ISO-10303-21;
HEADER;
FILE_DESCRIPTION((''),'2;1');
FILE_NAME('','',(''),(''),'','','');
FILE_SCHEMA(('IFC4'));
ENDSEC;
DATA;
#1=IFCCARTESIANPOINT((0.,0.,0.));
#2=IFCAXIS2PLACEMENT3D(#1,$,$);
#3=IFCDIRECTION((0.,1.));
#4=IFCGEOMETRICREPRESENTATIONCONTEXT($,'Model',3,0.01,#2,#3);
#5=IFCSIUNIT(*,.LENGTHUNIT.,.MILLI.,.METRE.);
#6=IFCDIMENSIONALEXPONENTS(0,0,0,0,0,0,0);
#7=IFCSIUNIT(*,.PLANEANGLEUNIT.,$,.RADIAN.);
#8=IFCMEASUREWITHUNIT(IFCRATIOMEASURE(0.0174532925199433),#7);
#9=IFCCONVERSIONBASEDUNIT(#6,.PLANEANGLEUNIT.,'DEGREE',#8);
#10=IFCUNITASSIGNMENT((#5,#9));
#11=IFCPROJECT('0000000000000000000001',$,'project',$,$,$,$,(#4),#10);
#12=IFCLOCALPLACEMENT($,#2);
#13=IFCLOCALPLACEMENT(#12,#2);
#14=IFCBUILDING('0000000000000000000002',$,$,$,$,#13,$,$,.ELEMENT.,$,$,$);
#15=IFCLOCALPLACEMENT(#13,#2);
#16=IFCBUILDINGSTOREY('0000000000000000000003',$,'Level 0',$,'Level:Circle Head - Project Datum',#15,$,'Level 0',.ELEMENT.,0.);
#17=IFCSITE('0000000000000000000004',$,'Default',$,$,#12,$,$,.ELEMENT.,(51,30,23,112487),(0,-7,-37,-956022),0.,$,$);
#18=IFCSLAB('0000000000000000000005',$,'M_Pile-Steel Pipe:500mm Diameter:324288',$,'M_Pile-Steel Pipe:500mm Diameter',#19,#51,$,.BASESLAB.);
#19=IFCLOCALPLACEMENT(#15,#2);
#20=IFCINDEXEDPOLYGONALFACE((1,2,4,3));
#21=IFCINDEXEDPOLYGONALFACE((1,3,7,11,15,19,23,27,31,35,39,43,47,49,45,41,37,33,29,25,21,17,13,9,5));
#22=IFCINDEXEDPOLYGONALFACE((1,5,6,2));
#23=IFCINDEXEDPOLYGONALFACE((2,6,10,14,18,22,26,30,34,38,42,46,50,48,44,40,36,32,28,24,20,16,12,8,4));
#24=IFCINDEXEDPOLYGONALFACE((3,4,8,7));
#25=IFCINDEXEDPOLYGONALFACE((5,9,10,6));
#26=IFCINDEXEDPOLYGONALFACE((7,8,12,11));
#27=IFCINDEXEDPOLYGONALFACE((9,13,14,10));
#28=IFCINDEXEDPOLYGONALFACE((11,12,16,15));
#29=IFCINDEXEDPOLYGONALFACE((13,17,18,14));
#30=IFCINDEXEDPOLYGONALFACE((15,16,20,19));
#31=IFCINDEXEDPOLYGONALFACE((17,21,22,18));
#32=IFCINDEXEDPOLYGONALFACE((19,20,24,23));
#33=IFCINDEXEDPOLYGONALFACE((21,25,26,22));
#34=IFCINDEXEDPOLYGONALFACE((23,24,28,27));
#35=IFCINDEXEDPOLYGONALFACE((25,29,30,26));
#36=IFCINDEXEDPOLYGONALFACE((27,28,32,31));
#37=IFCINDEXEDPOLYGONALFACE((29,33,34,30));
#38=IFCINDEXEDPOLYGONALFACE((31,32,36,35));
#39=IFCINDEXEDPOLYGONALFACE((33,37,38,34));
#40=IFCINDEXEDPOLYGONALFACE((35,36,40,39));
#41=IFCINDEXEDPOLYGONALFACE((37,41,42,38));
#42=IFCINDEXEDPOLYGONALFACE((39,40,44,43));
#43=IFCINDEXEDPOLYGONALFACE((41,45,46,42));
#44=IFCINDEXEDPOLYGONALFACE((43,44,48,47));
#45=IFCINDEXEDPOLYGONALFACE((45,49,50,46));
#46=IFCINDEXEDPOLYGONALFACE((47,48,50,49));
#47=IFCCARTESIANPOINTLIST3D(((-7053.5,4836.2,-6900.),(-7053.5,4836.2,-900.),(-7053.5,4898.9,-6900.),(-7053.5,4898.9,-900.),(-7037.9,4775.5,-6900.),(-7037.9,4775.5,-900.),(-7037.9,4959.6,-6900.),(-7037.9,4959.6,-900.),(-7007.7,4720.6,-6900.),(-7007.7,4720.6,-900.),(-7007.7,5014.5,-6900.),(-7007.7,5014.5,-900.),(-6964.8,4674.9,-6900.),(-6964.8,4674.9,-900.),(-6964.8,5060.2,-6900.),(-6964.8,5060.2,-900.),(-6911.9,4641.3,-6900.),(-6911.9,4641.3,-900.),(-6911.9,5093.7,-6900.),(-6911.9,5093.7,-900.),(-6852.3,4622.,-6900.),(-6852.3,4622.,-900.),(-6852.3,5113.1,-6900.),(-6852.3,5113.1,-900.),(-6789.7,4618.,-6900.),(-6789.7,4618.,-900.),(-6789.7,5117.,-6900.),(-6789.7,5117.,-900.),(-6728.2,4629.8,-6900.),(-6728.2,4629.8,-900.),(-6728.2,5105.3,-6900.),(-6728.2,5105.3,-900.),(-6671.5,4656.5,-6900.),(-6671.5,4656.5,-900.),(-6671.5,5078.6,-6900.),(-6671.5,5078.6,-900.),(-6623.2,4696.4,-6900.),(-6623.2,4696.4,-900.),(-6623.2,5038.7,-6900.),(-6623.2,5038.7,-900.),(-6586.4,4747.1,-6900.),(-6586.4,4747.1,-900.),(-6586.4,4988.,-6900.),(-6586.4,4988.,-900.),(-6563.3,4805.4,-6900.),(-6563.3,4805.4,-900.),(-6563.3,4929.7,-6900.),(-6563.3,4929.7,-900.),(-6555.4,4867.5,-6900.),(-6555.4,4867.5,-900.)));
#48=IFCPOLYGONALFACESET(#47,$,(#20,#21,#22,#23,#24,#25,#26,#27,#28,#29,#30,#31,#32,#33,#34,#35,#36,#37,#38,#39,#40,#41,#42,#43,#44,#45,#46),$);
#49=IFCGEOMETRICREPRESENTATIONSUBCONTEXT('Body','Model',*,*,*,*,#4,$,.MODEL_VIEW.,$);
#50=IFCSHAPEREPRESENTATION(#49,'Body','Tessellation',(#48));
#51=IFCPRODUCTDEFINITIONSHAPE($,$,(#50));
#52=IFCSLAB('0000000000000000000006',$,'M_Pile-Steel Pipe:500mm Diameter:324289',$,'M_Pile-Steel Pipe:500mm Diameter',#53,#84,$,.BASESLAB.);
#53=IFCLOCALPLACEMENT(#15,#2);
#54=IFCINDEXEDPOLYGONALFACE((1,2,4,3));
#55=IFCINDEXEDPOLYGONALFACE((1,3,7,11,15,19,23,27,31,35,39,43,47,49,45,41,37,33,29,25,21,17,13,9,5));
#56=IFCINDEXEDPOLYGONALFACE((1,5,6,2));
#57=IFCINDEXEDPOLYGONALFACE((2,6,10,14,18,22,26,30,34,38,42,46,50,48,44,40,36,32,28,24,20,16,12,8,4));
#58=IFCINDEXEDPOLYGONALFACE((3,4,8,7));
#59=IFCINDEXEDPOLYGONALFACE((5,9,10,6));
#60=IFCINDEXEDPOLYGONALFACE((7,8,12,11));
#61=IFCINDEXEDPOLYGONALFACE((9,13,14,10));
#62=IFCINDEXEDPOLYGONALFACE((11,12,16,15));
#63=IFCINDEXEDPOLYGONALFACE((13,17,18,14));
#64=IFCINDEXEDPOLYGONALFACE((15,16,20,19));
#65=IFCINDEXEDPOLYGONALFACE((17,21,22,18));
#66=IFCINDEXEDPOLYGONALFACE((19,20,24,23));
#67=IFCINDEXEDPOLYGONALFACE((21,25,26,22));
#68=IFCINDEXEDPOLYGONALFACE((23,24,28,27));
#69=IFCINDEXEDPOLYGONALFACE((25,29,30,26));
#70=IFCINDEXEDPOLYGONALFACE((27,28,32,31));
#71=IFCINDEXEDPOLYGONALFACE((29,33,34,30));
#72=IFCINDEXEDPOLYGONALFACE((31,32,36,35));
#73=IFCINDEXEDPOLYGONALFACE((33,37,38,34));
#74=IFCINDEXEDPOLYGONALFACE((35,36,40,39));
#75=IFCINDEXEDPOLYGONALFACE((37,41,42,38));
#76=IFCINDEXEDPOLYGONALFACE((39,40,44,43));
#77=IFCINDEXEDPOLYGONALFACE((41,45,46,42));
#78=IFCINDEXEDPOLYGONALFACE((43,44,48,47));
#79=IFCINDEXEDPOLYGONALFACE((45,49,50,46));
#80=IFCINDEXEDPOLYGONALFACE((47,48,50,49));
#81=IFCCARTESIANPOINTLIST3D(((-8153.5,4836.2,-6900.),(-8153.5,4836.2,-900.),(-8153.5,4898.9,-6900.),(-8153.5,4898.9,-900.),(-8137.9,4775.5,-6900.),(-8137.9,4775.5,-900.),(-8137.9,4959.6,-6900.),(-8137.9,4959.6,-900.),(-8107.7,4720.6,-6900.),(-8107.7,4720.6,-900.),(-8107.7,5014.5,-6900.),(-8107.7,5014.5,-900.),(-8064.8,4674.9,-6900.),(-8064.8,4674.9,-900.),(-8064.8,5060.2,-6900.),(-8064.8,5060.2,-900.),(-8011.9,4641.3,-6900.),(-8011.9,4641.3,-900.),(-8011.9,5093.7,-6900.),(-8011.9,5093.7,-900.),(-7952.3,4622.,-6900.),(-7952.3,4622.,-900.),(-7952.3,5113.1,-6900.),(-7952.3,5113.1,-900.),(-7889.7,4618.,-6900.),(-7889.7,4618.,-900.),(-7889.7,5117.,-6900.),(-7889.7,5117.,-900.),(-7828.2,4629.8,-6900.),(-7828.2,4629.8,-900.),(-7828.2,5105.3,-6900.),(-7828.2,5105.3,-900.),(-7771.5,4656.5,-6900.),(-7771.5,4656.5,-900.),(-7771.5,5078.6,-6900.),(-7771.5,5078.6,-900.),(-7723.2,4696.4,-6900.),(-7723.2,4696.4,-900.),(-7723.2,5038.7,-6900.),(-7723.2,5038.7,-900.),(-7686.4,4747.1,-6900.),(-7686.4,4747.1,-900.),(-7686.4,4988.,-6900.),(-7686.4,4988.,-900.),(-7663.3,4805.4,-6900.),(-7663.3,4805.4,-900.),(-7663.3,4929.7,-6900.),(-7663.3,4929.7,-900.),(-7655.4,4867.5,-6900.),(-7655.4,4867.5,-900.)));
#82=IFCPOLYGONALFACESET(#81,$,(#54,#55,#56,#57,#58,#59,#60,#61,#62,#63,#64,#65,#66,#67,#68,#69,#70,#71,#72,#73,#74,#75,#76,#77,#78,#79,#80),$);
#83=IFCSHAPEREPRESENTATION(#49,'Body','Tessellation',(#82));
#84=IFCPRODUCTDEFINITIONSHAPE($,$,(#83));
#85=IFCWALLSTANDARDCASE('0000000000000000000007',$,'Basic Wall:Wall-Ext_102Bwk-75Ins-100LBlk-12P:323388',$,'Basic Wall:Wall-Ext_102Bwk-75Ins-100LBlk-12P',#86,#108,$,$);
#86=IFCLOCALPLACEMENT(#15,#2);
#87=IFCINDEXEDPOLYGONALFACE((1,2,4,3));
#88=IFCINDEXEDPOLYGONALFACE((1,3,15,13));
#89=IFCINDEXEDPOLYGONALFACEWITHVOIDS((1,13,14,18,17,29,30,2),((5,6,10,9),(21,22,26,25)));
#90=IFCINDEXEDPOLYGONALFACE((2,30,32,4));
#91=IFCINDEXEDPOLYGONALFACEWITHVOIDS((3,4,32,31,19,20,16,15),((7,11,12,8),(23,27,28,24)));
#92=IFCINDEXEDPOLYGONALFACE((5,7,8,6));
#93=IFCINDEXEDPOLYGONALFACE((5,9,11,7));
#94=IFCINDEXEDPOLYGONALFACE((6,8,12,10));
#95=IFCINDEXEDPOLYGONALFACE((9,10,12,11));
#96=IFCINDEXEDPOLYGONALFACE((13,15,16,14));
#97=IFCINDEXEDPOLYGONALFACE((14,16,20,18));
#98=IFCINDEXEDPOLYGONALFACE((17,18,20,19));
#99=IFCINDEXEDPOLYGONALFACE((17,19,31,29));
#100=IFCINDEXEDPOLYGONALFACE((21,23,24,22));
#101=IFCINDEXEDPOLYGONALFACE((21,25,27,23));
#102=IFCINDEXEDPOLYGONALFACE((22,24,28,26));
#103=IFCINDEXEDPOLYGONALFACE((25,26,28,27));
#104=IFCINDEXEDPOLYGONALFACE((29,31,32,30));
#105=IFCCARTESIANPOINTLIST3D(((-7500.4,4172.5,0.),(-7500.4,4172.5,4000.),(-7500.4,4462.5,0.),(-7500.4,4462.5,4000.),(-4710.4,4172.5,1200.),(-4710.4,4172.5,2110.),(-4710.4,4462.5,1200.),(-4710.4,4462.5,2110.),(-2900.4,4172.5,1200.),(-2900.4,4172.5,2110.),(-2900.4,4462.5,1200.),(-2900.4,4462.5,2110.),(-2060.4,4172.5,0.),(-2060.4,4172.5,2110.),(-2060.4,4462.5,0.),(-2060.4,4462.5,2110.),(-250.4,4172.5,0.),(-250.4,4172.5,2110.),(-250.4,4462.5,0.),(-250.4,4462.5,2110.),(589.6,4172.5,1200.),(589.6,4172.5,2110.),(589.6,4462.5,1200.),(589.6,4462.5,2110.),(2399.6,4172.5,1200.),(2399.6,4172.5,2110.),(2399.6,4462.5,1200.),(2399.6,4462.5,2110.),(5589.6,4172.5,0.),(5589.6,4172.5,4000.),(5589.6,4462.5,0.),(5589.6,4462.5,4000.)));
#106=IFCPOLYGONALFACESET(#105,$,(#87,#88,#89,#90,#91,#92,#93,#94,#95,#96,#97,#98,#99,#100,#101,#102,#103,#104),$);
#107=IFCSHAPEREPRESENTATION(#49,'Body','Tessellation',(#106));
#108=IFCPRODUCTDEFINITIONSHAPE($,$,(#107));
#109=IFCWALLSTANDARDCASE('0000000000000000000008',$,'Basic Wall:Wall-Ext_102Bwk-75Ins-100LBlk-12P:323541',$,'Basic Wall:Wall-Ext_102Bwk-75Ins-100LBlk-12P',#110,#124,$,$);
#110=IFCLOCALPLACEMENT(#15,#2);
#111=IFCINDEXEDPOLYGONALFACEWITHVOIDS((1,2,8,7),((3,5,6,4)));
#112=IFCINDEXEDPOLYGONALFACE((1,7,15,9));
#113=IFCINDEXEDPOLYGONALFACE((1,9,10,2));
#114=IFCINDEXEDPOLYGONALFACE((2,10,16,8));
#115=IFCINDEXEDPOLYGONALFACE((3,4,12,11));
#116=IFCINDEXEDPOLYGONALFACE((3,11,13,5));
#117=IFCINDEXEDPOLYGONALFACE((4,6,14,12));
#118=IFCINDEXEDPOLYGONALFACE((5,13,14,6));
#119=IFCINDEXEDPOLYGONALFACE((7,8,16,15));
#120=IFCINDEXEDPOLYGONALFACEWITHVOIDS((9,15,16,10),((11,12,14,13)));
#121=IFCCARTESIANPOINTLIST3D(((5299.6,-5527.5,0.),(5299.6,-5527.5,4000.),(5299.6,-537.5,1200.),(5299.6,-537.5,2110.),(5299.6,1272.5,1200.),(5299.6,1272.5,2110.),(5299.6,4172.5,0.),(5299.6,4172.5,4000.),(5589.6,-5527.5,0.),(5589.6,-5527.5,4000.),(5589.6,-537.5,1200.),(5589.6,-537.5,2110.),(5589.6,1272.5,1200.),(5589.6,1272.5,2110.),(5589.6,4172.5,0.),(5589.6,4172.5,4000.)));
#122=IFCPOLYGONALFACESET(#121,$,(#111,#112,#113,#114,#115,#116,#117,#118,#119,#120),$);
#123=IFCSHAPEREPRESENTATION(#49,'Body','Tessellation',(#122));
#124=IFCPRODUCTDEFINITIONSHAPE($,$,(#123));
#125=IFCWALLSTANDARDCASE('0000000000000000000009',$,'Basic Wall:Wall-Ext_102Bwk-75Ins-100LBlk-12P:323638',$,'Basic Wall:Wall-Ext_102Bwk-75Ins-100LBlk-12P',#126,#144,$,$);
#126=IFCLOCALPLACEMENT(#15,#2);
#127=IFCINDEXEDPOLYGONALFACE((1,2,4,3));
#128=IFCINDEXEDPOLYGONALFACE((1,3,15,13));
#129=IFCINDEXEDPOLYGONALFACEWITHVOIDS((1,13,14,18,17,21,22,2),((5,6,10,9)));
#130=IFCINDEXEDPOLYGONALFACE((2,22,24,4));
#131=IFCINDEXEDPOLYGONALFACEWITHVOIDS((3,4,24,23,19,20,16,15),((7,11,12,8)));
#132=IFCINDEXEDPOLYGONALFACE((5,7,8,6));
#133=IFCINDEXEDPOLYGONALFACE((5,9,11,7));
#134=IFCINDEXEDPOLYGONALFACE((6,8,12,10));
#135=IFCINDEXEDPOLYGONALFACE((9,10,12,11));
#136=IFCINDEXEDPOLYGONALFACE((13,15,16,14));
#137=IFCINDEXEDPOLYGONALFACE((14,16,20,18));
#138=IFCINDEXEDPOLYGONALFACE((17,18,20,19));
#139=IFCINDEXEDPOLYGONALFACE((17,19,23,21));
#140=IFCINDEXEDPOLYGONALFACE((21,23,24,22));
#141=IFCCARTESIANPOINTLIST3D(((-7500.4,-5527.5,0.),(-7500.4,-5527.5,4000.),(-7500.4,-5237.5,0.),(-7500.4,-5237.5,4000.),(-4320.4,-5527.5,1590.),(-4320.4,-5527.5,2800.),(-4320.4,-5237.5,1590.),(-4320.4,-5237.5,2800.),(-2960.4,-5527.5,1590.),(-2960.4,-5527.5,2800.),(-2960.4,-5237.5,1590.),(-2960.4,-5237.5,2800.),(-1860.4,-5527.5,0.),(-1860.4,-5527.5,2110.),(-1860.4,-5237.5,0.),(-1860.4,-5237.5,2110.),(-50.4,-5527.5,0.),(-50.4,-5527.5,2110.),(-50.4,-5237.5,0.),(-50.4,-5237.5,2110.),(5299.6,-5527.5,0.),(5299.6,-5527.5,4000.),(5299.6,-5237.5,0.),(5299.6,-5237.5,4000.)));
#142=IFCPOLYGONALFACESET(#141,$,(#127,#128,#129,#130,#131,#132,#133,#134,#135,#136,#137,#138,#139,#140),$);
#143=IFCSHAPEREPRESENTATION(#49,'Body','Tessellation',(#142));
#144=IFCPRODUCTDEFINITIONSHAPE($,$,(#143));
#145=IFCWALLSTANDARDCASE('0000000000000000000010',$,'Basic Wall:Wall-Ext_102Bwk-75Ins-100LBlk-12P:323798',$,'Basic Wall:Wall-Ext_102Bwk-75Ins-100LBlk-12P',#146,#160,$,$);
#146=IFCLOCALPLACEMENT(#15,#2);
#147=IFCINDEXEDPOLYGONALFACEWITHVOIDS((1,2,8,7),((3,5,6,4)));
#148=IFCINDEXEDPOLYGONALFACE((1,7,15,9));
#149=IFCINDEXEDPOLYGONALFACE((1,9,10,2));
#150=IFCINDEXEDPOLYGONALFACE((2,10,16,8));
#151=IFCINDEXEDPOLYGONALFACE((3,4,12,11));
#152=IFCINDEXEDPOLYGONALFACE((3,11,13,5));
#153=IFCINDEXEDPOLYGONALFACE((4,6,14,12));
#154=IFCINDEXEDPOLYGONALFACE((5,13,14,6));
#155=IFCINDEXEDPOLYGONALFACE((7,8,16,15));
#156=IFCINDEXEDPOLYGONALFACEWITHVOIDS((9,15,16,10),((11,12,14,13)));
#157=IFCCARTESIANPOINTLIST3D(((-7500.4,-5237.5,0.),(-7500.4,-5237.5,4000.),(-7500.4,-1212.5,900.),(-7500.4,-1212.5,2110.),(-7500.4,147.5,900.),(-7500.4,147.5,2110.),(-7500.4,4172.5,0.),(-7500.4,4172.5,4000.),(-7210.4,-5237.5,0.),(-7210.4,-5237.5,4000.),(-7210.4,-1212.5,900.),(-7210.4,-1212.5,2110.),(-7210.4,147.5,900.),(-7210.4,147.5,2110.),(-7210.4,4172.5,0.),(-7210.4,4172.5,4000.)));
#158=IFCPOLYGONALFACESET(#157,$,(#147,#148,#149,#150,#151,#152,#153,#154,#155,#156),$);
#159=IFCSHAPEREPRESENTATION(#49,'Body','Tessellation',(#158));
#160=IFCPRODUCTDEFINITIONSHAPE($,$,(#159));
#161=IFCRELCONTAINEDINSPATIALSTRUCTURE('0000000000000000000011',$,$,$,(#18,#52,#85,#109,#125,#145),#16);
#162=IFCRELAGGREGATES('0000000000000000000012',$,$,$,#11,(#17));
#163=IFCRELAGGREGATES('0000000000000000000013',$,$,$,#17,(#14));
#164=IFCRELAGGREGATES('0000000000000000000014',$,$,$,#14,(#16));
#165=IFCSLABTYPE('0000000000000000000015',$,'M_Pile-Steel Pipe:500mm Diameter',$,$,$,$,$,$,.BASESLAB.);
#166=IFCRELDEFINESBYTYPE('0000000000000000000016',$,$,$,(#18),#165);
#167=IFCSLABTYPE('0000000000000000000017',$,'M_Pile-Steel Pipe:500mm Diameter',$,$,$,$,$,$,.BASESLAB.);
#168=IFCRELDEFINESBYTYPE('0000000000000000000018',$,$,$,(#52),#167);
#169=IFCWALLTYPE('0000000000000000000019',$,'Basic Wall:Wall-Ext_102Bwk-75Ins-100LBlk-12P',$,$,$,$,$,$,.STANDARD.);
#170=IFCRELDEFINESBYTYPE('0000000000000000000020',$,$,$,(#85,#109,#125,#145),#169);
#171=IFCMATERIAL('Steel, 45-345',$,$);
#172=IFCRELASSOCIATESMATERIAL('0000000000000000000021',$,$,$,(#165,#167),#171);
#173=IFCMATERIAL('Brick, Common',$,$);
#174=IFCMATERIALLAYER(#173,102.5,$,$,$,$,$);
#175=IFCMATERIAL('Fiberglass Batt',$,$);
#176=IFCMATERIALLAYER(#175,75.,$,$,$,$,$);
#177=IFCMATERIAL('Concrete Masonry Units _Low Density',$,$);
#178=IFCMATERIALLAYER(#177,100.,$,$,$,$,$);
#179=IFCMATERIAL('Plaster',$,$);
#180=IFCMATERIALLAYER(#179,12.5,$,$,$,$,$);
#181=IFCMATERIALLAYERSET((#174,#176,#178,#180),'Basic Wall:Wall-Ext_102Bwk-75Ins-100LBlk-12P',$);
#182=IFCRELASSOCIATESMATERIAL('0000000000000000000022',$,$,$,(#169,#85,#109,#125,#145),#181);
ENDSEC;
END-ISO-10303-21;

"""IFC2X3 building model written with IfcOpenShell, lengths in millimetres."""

from ifc_helpers import new_model, entity, si_unit, converted_unit, direction, frame, frame_2d, origin, place, context, subcontext, project, spatial, rectangle, circle, extrude, material, layer, layer_set, layer_usage, type_object, element, save


model = new_model("IFC2X3")

# Units and contexts
model_context = context("Model", 3, precision=0.01, world=origin(), true_north=direction((0.0, 1.0)))
body_context = subcontext(model_context, "Body", "Model", "MODEL_VIEW")
ifc_project = project(units=[si_unit("LENGTHUNIT", "METRE", prefix="MILLI"), converted_unit("PLANEANGLEUNIT", "DEGREE", entity("IfcRatioMeasure", 0.0174532925199433), si_unit("PLANEANGLEUNIT", "RADIAN"), dimensions=[0, 0, 0, 0, 0, 0, 0])], contexts=[model_context])

# Site, building, storey
site_placement = place(None, origin())
site = spatial("IfcSite", under=ifc_project, at=site_placement, Name="Default", CompositionType="ELEMENT", RefLatitude=(51, 30, 23, 112487), RefLongitude=(0, -7, -37, -956022), RefElevation=0.0)
building_placement = place(site_placement, origin())
building = spatial("IfcBuilding", under=site, at=building_placement, CompositionType="ELEMENT")
storey_placement = place(building_placement, origin())
storey = spatial("IfcBuildingStorey", under=building, at=storey_placement, Name="Level 0", ObjectType="Level:Circle Head - Project Datum", LongName="Level 0", CompositionType="ELEMENT", Elevation=0.0)

# Slabs
ifc_material_1 = material(Name="Steel, 45-345")
slab_type_1 = type_object("IfcSlabType", Name="M_Pile-Steel Pipe:500mm Diameter", PredefinedType="BASESLAB", material=ifc_material_1)
slab_1_placement = place(storey_placement, origin())
element("IfcSlab", 1, at=slab_1_placement, inside=storey, type_object=slab_type_1, Name="M_Pile-Steel Pipe:500mm Diameter:324288", ObjectType="M_Pile-Steel Pipe:500mm Diameter", PredefinedType="BASESLAB", context=body_context, shape_type="SweptSolid", body=[
    extrude(circle(Radius=250.0, at=frame_2d((0.0, 0.0), x_axis=(1.0, 0.0))), frame((-6805.4, 4867.5, -6900.0)), (0.0, 0.0, 1.0), 6000.0),
])
slab_type_2 = type_object("IfcSlabType", Name="M_Pile-Steel Pipe:500mm Diameter", PredefinedType="BASESLAB", material=ifc_material_1)
slab_2_placement = place(storey_placement, origin())
element("IfcSlab", 2, at=slab_2_placement, inside=storey, type_object=slab_type_2, Name="M_Pile-Steel Pipe:500mm Diameter:324289", ObjectType="M_Pile-Steel Pipe:500mm Diameter", PredefinedType="BASESLAB", context=body_context, shape_type="SweptSolid", body=[
    extrude(circle(Radius=250.0, at=frame_2d((0.0, 0.0), x_axis=(1.0, 0.0))), frame((-7905.4, 4867.5, -6900.0)), (0.0, 0.0, 1.0), 6000.0),
])

# Wall, openings
ifc_material_2 = material(Name="Brick, Common")
ifc_layer_1 = layer(ifc_material_2, 102.5)
ifc_material_3 = material(Name="Fiberglass Batt")
ifc_layer_2 = layer(ifc_material_3, 75.0)
ifc_material_4 = material(Name="Concrete Masonry Units _Low Density")
ifc_layer_3 = layer(ifc_material_4, 100.0)
ifc_material_5 = material(Name="Plaster")
ifc_layer_4 = layer(ifc_material_5, 12.5)
ifc_layer_set_1 = layer_set([ifc_layer_1, ifc_layer_2, ifc_layer_3, ifc_layer_4], Name="Basic Wall:Wall-Ext_102Bwk-75Ins-100LBlk-12P")
ifc_layer_usage_1 = layer_usage(ifc_layer_set_1, "AXIS2", "NEGATIVE", 145.0)
wall_type = type_object("IfcWallType", Name="Basic Wall:Wall-Ext_102Bwk-75Ins-100LBlk-12P", PredefinedType="STANDARD", material=ifc_layer_set_1)
wall_1_placement = place(storey_placement, frame((-7500.4, 4317.5, 0.0)))
wall_1 = element("IfcWallStandardCase", 3, at=wall_1_placement, inside=storey, type_object=wall_type, material=ifc_layer_usage_1, Name="Basic Wall:Wall-Ext_102Bwk-75Ins-100LBlk-12P:323388", ObjectType="Basic Wall:Wall-Ext_102Bwk-75Ins-100LBlk-12P", context=body_context, shape_type="SweptSolid", body=[
    extrude(rectangle(XDim=13090.0, YDim=290.0, at=frame_2d((6545.0, 0.0), x_axis=(-1.0, 0.0))), origin(), (0.0, 0.0, 1.0), 4000.0),
])
opening_1_placement = place(wall_1_placement, frame((7250.0, 145.0, 0.0)))
element("IfcOpeningElement", 4, at=opening_1_placement, cuts=wall_1, ObjectType="Opening", context=body_context, shape_type="SweptSolid", body=[
    extrude(rectangle(XDim=2110.0, YDim=1810.0, at=frame_2d((1055.0, 905.0), x_axis=(-1.0, 0.0))), frame((0.0, 0.0, 0.0), z_axis=(0.0, -1.0, 0.0), x_axis=(0.0, 0.0, 1.0)), (0.0, 0.0, 1.0), 290.0),
])
opening_2_placement = place(wall_1_placement, frame((2790.0, -145.0, 1200.0)))
element("IfcOpeningElement", 5, at=opening_2_placement, cuts=wall_1, ObjectType="Opening", context=body_context, shape_type="SweptSolid", body=[
    extrude(rectangle(XDim=910.0, YDim=1810.0, at=frame_2d((455.0, 905.0), x_axis=(-1.0, 0.0))), frame((0.0, 0.0, 0.0), z_axis=(0.0, 1.0, 0.0), x_axis=(0.0, 0.0, 1.0)), (0.0, 0.0, 1.0), 290.0),
])
opening_3_placement = place(wall_1_placement, frame((8090.0, -145.0, 1200.0)))
element("IfcOpeningElement", 6, at=opening_3_placement, cuts=wall_1, ObjectType="Opening", context=body_context, shape_type="SweptSolid", body=[
    extrude(rectangle(XDim=910.0, YDim=1810.0, at=frame_2d((455.0, 905.0), x_axis=(-1.0, 0.0))), frame((0.0, 0.0, 0.0), z_axis=(0.0, 1.0, 0.0), x_axis=(0.0, 0.0, 1.0)), (0.0, 0.0, 1.0), 290.0),
])

# Wall, opening
ifc_layer_usage_2 = layer_usage(ifc_layer_set_1, "AXIS2", "NEGATIVE", 145.0)
wall_2_placement = place(storey_placement, frame((5444.6, 4172.5, 0.0), z_axis=(0.0, 0.0, 1.0), x_axis=(0.0, -1.0, 0.0)))
wall_2 = element("IfcWallStandardCase", 7, at=wall_2_placement, inside=storey, type_object=wall_type, material=ifc_layer_usage_2, Name="Basic Wall:Wall-Ext_102Bwk-75Ins-100LBlk-12P:323541", ObjectType="Basic Wall:Wall-Ext_102Bwk-75Ins-100LBlk-12P", context=body_context, shape_type="SweptSolid", body=[
    extrude(rectangle(XDim=9700.0, YDim=290.0, at=frame_2d((4850.0, 0.0), x_axis=(-1.0, 0.0))), origin(), (0.0, 0.0, 1.0), 4000.0),
])
opening_4_placement = place(wall_2_placement, frame((2900.0, -145.0, 1200.0)))
element("IfcOpeningElement", 8, at=opening_4_placement, cuts=wall_2, ObjectType="Opening", context=body_context, shape_type="SweptSolid", body=[
    extrude(rectangle(XDim=910.0, YDim=1810.0, at=frame_2d((455.0, 905.0), x_axis=(-1.0, 0.0))), frame((0.0, 0.0, 0.0), z_axis=(0.0, 1.0, 0.0), x_axis=(0.0, 0.0, 1.0)), (0.0, 0.0, 1.0), 290.0),
])

# Wall, openings
ifc_layer_usage_3 = layer_usage(ifc_layer_set_1, "AXIS2", "NEGATIVE", 145.0)
wall_3_placement = place(storey_placement, frame((5299.6, -5382.5, 0.0), z_axis=(0.0, 0.0, 1.0), x_axis=(-1.0, 0.0, 0.0)))
wall_3 = element("IfcWallStandardCase", 9, at=wall_3_placement, inside=storey, type_object=wall_type, material=ifc_layer_usage_3, Name="Basic Wall:Wall-Ext_102Bwk-75Ins-100LBlk-12P:323638", ObjectType="Basic Wall:Wall-Ext_102Bwk-75Ins-100LBlk-12P", context=body_context, shape_type="SweptSolid", body=[
    extrude(rectangle(XDim=12800.0, YDim=290.0, at=frame_2d((6400.0, 0.0), x_axis=(-1.0, 0.0))), origin(), (0.0, 0.0, 1.0), 4000.0),
])
opening_5_placement = place(wall_3_placement, frame((7160.0, 145.0, 0.0)))
element("IfcOpeningElement", 10, at=opening_5_placement, cuts=wall_3, ObjectType="Opening", context=body_context, shape_type="SweptSolid", body=[
    extrude(rectangle(XDim=2110.0, YDim=1810.0, at=frame_2d((1055.0, 905.0), x_axis=(-1.0, 0.0))), frame((0.0, 0.0, 0.0), z_axis=(0.0, -1.0, 0.0), x_axis=(0.0, 0.0, 1.0)), (0.0, 0.0, 1.0), 290.0),
])
opening_6_placement = place(wall_3_placement, frame((8260.0, -145.0, 1590.0)))
element("IfcOpeningElement", 11, at=opening_6_placement, cuts=wall_3, ObjectType="Opening", context=body_context, shape_type="SweptSolid", body=[
    extrude(rectangle(XDim=1210.0, YDim=1360.0, at=frame_2d((605.0, 680.0), x_axis=(-1.0, 0.0))), frame((0.0, 0.0, 0.0), z_axis=(0.0, 1.0, 0.0), x_axis=(0.0, 0.0, 1.0)), (0.0, 0.0, 1.0), 290.0),
])

# Wall, opening
ifc_layer_usage_4 = layer_usage(ifc_layer_set_1, "AXIS2", "NEGATIVE", 145.0)
wall_4_placement = place(storey_placement, frame((-7355.4, -5237.5, 0.0), z_axis=(0.0, 0.0, 1.0), x_axis=(0.0, 1.0, 0.0)))
wall_4 = element("IfcWallStandardCase", 12, at=wall_4_placement, inside=storey, type_object=wall_type, material=ifc_layer_usage_4, Name="Basic Wall:Wall-Ext_102Bwk-75Ins-100LBlk-12P:323798", ObjectType="Basic Wall:Wall-Ext_102Bwk-75Ins-100LBlk-12P", context=body_context, shape_type="SweptSolid", body=[
    extrude(rectangle(XDim=9410.0, YDim=290.0, at=frame_2d((4705.0, 0.0), x_axis=(-1.0, 0.0))), origin(), (0.0, 0.0, 1.0), 4000.0),
])
opening_7_placement = place(wall_4_placement, frame((5385.0, 145.0, 900.0)))
element("IfcOpeningElement", 13, at=opening_7_placement, cuts=wall_4, ObjectType="Opening", context=body_context, shape_type="SweptSolid", body=[
    extrude(rectangle(XDim=1210.0, YDim=1360.0, at=frame_2d((605.0, 680.0), x_axis=(-1.0, 0.0))), frame((0.0, 0.0, 0.0), z_axis=(0.0, -1.0, 0.0), x_axis=(0.0, 0.0, 1.0)), (0.0, 0.0, 1.0), 290.0),
])

save(model, "model.ifc")
